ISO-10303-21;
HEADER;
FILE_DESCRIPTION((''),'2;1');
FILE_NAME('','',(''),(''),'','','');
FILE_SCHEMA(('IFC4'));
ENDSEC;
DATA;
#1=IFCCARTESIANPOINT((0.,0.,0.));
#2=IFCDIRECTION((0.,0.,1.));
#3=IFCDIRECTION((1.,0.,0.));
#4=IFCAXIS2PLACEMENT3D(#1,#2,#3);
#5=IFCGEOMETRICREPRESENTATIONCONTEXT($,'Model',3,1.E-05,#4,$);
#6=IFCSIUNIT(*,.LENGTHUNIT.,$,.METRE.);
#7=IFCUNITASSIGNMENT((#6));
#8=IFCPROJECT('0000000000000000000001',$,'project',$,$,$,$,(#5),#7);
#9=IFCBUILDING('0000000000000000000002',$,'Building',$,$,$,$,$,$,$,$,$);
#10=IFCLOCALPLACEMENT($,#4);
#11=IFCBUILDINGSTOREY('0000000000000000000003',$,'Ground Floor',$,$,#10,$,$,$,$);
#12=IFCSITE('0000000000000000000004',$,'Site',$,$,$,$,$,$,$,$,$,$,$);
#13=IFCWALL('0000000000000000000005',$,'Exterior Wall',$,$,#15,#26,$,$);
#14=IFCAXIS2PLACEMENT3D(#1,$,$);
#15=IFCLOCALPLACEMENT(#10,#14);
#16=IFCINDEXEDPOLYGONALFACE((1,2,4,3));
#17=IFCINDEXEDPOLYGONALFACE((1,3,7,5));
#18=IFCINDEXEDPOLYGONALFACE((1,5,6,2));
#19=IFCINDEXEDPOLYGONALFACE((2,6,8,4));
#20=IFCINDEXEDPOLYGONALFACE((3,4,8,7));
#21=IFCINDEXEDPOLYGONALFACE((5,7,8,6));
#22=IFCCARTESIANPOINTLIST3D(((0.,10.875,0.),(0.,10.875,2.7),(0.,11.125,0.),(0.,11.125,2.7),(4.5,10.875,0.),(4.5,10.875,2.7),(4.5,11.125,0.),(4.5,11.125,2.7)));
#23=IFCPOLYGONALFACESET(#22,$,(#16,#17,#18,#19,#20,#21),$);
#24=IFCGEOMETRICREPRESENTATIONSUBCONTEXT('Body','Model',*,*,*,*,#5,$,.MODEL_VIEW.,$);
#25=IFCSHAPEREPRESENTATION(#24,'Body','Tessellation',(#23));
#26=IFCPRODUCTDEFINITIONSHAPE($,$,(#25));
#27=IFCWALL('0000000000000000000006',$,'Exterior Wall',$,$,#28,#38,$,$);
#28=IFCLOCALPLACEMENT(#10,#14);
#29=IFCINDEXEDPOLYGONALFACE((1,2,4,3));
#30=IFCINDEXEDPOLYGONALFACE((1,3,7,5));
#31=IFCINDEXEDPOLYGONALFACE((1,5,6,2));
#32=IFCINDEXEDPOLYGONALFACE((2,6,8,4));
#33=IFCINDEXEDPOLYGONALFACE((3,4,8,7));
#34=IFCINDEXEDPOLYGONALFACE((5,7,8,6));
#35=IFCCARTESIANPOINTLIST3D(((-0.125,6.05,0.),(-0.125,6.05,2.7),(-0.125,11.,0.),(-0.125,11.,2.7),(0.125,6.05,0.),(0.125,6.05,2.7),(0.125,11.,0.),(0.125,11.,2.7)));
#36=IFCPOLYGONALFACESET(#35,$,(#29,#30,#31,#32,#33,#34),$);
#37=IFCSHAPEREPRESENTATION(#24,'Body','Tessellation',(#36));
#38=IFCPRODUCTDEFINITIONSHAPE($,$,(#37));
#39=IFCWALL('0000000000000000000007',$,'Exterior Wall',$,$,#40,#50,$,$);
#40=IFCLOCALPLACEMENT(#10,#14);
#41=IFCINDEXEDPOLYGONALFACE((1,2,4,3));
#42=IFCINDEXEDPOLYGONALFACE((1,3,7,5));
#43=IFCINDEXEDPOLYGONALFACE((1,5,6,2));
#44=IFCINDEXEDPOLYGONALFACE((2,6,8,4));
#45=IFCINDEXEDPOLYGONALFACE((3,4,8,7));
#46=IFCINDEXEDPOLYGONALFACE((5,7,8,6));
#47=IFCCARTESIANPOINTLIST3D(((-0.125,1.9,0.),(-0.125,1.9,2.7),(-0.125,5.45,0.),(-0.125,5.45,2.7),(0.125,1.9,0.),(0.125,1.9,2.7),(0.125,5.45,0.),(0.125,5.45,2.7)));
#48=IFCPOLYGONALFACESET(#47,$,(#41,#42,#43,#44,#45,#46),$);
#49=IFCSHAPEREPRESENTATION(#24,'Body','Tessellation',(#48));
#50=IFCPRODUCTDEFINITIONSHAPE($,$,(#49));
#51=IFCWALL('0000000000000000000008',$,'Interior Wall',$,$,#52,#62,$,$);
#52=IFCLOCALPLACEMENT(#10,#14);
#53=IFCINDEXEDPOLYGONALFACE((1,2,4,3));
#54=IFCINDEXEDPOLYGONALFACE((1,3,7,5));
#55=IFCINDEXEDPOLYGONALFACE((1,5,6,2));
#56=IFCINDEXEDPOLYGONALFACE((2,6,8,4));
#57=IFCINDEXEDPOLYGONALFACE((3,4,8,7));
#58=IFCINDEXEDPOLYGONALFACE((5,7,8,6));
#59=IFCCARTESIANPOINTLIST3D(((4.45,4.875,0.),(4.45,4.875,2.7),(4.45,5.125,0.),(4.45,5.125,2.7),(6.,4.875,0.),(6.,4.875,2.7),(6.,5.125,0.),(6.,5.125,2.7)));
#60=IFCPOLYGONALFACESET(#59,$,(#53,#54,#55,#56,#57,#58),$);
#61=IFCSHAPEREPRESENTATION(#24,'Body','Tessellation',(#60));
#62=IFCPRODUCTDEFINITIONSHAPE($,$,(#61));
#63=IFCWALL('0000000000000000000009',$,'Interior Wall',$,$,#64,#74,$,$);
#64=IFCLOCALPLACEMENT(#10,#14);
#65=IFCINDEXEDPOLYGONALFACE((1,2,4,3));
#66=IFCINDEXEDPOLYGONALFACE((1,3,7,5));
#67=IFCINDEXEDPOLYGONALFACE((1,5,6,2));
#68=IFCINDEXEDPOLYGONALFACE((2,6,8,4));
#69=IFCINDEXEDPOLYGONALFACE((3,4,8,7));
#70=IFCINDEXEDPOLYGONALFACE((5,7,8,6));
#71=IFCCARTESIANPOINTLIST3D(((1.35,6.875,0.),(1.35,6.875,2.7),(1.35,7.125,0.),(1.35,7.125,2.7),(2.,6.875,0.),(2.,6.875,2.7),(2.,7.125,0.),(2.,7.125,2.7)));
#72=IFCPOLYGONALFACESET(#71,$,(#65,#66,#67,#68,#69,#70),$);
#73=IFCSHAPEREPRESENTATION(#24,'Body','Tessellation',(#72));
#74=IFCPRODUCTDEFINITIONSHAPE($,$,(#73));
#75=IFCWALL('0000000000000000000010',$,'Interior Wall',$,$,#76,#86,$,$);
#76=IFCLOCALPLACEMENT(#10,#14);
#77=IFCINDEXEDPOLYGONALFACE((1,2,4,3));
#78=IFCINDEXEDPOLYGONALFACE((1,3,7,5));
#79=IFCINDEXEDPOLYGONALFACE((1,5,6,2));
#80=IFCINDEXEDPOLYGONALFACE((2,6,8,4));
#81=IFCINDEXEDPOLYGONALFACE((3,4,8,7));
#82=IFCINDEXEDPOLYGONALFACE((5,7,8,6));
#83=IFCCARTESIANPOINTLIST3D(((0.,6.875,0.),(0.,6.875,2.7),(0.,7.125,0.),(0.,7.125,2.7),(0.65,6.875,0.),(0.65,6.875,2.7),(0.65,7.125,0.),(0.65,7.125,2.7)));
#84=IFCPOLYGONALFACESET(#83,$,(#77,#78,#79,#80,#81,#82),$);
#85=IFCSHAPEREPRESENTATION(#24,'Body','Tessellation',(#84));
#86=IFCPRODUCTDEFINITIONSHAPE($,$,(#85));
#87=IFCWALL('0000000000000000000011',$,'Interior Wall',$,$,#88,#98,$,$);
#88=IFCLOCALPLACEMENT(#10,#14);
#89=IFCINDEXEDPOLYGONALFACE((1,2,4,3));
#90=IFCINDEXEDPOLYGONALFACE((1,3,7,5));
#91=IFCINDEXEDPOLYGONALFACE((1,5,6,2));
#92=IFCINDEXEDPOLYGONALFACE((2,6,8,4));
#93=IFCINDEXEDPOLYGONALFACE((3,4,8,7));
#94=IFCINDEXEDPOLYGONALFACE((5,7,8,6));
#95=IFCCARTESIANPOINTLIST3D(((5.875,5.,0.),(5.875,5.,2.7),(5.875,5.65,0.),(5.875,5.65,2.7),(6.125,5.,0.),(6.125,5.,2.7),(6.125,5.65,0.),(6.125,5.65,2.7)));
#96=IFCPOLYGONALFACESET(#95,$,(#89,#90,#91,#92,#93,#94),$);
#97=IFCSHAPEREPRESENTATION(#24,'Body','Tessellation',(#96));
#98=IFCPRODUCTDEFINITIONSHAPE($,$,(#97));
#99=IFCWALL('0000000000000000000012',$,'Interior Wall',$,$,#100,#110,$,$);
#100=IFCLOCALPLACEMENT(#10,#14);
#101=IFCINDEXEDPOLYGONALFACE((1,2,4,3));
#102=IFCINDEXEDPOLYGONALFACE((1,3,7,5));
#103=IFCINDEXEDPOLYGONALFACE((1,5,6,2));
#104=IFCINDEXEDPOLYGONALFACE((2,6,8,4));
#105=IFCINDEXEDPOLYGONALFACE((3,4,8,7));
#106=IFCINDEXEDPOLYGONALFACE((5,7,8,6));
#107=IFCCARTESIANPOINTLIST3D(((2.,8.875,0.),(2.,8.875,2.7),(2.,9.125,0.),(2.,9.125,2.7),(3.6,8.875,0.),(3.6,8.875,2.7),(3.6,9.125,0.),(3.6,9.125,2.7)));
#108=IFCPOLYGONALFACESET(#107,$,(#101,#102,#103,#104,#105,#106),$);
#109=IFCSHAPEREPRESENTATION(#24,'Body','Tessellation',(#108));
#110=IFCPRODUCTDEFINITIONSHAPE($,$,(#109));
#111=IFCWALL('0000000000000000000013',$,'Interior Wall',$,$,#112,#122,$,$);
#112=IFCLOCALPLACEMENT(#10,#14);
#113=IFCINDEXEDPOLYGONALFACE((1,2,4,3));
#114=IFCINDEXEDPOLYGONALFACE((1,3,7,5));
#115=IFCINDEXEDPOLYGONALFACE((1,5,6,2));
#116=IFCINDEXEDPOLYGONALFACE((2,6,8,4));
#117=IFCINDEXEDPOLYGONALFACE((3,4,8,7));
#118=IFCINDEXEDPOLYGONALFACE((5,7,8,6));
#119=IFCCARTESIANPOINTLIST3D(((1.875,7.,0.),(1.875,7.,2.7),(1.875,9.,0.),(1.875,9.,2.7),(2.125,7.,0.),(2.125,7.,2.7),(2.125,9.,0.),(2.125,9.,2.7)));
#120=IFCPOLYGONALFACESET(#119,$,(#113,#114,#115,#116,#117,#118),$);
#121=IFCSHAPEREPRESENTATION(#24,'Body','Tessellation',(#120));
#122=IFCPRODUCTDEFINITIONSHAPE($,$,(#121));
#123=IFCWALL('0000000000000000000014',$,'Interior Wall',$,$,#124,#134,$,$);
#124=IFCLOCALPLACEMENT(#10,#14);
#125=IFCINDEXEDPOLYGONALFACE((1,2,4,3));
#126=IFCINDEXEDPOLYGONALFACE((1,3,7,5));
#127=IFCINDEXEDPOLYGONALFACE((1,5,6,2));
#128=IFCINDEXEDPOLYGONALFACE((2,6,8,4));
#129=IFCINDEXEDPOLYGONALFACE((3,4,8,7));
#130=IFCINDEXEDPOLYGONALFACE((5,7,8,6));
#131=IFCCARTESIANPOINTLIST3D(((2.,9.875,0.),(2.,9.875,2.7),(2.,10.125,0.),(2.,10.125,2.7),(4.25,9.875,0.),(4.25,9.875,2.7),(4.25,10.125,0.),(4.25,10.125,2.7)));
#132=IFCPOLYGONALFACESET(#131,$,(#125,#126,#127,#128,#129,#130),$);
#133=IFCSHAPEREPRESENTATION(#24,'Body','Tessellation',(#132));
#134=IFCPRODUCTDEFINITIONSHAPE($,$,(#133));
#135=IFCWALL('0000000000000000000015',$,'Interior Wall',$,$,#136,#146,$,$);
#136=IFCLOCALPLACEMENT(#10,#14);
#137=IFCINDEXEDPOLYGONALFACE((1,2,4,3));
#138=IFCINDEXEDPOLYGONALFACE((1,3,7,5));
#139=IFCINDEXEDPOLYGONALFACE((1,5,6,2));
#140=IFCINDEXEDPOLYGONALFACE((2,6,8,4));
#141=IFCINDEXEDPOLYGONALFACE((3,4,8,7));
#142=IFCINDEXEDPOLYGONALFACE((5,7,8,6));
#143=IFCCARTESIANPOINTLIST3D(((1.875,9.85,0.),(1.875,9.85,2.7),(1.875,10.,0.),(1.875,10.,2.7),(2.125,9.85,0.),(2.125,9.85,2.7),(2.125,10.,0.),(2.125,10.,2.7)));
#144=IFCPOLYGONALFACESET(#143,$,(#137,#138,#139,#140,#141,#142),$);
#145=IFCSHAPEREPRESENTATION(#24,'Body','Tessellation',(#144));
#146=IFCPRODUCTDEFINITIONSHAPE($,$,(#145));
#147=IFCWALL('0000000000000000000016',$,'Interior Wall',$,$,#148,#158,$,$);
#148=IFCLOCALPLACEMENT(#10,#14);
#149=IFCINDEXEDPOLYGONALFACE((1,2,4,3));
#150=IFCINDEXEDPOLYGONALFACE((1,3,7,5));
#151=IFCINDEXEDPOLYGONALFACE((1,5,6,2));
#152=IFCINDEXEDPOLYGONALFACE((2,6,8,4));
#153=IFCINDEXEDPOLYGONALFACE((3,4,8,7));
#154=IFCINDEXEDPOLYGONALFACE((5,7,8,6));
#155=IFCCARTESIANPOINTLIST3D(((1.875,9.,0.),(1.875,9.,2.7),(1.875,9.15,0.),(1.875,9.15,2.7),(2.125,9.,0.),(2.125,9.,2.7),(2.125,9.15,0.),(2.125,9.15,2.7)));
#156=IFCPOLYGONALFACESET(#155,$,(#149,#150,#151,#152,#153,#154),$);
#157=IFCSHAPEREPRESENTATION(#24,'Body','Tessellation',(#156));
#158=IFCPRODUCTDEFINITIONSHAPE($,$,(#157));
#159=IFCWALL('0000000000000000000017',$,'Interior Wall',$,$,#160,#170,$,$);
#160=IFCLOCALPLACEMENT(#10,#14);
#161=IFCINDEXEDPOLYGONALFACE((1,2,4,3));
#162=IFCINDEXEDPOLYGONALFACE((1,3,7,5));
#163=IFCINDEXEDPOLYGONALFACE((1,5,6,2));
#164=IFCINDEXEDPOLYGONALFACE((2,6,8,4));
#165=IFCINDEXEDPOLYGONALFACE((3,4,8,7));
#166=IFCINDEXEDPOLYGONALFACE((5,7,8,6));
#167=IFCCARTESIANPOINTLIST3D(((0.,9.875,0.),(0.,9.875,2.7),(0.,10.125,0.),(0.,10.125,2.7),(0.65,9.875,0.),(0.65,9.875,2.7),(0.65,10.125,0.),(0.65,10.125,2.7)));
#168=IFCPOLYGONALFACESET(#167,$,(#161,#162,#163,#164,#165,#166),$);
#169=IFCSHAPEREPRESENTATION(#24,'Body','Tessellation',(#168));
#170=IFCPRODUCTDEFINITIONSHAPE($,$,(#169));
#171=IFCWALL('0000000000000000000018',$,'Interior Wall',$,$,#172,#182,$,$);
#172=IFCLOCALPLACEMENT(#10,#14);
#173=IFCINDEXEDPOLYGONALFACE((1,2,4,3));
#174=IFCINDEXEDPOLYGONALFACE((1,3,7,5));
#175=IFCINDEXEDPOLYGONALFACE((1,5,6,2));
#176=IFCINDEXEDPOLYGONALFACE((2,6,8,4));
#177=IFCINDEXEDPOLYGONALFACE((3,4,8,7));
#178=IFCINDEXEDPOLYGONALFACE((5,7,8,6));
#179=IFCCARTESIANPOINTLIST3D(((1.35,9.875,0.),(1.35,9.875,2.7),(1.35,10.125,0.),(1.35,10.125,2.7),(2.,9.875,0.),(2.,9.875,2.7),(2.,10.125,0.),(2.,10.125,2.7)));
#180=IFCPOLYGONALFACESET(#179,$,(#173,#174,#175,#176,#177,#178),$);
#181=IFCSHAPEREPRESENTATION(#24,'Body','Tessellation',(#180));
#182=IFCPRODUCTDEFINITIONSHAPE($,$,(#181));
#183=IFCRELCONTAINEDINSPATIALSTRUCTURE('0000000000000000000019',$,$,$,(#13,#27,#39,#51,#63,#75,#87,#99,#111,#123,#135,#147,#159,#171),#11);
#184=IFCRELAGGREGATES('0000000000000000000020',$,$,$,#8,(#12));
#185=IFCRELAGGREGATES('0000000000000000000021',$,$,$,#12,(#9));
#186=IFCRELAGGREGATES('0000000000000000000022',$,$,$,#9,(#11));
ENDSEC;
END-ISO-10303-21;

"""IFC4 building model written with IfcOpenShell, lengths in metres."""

from ifc_helpers import new_model, si_unit, frame, origin_with_axes, place, context, subcontext, project, spatial, indexed_curve, outline, extrude, element, save


model = new_model("IFC4")

# Units and contexts
model_context = context("Model", 3, precision=1e-05, world=origin_with_axes())
body_context = subcontext(model_context, "Body", "Model", "MODEL_VIEW")
ifc_project = project(units=[si_unit("LENGTHUNIT", "METRE")], contexts=[model_context])

# Site, building, storey
site = spatial("IfcSite", under=ifc_project, Name="Site")
building = spatial("IfcBuilding", under=site, Name="Building")
storey_placement = place(None, origin_with_axes())
storey = spatial("IfcBuildingStorey", under=building, at=storey_placement, Name="Ground Floor")

# Walls
wall_1_placement = place(storey_placement, frame((4.5, 11.0, 0.0), z_axis=(0.0, 0.0, 1.0), x_axis=(-1.0, 0.0, 0.0)))
element("IfcWall", 1, at=wall_1_placement, inside=storey, Name="Exterior Wall", context=body_context, shape_type="SweptSolid", body=[
    extrude(outline(indexed_curve([(0.0, 0.0), (0.0, 0.25), (4.5, 0.25), (4.5, 0.0), (0.0, 0.0)], self_intersect=False)), frame((0.0, -0.125, 0.0), z_axis=(0.0, 0.0, 1.0), x_axis=(1.0, 0.0, 0.0)), (0.0, 0.0, 1.0), 2.7),
])
wall_2_placement = place(storey_placement, frame((0.0, 11.0, 0.0), z_axis=(0.0, 0.0, 1.0), x_axis=(0.0, -1.0, 0.0)))
element("IfcWall", 2, at=wall_2_placement, inside=storey, Name="Exterior Wall", context=body_context, shape_type="SweptSolid", body=[
    extrude(outline(indexed_curve([(0.0, 0.0), (0.0, 0.25), (4.95, 0.25), (4.95, 0.0), (0.0, 0.0)], self_intersect=False)), frame((0.0, -0.125, 0.0), z_axis=(0.0, 0.0, 1.0), x_axis=(1.0, 0.0, 0.0)), (0.0, 0.0, 1.0), 2.7),
])
wall_3_placement = place(storey_placement, frame((0.0, 5.45, 0.0), z_axis=(0.0, 0.0, 1.0), x_axis=(0.0, -1.0, 0.0)))
element("IfcWall", 3, at=wall_3_placement, inside=storey, Name="Exterior Wall", context=body_context, shape_type="SweptSolid", body=[
    extrude(outline(indexed_curve([(0.0, 0.0), (0.0, 0.25), (3.55, 0.25), (3.55, 0.0), (0.0, 0.0)], self_intersect=False)), frame((0.0, -0.125, 0.0), z_axis=(0.0, 0.0, 1.0), x_axis=(1.0, 0.0, 0.0)), (0.0, 0.0, 1.0), 2.7),
])
wall_4_placement = place(storey_placement, frame((6.0, 5.0, 0.0), z_axis=(0.0, 0.0, 1.0), x_axis=(-1.0, 0.0, 0.0)))
element("IfcWall", 4, at=wall_4_placement, inside=storey, Name="Interior Wall", context=body_context, shape_type="SweptSolid", body=[
    extrude(outline(indexed_curve([(0.0, 0.0), (0.0, 0.25), (1.55, 0.25), (1.55, 0.0), (0.0, 0.0)], self_intersect=False)), frame((0.0, -0.125, 0.0), z_axis=(0.0, 0.0, 1.0), x_axis=(1.0, 0.0, 0.0)), (0.0, 0.0, 1.0), 2.7),
])
for number, where, z_axis, x_axis, name in (
    (5, (2.0, 7.0, 0.0), (0.0, 0.0, 1.0), (-1.0, 0.0, 0.0), "Interior Wall"),
    (6, (0.65, 7.0, 0.0), (0.0, 0.0, 1.0), (-1.0, 0.0, 0.0), "Interior Wall"),
):
    element("IfcWall", number, at=place(storey_placement, frame(where, z_axis=z_axis, x_axis=x_axis)), inside=storey, Name=name, context=body_context, shape_type="SweptSolid", body=[
        extrude(outline(indexed_curve([(0.0, 0.0), (0.0, 0.25), (0.65, 0.25), (0.65, 0.0), (0.0, 0.0)], self_intersect=False)), frame((0.0, -0.125, 0.0), z_axis=(0.0, 0.0, 1.0), x_axis=(1.0, 0.0, 0.0)), (0.0, 0.0, 1.0), 2.7),
    ])
wall_5_placement = place(storey_placement, frame((6.0, 5.0, 0.0), z_axis=(0.0, 0.0, 1.0), x_axis=(0.0, 1.0, 0.0)))
element("IfcWall", 7, at=wall_5_placement, inside=storey, Name="Interior Wall", context=body_context, shape_type="SweptSolid", body=[
    extrude(outline(indexed_curve([(0.0, 0.0), (0.0, 0.25), (0.65, 0.25), (0.65, 0.0), (0.0, 0.0)], self_intersect=False)), frame((0.0, -0.125, 0.0), z_axis=(0.0, 0.0, 1.0), x_axis=(1.0, 0.0, 0.0)), (0.0, 0.0, 1.0), 2.7),
])
wall_6_placement = place(storey_placement, frame((3.6, 9.0, 0.0), z_axis=(0.0, 0.0, 1.0), x_axis=(-1.0, 0.0, 0.0)))
element("IfcWall", 8, at=wall_6_placement, inside=storey, Name="Interior Wall", context=body_context, shape_type="SweptSolid", body=[
    extrude(outline(indexed_curve([(0.0, 0.0), (0.0, 0.25), (1.6, 0.25), (1.6, 0.0), (0.0, 0.0)], self_intersect=False)), frame((0.0, -0.125, 0.0), z_axis=(0.0, 0.0, 1.0), x_axis=(1.0, 0.0, 0.0)), (0.0, 0.0, 1.0), 2.7),
])
wall_7_placement = place(storey_placement, frame((2.0, 9.0, 0.0), z_axis=(0.0, 0.0, 1.0), x_axis=(0.0, -1.0, 0.0)))
element("IfcWall", 9, at=wall_7_placement, inside=storey, Name="Interior Wall", context=body_context, shape_type="SweptSolid", body=[
    extrude(outline(indexed_curve([(0.0, 0.0), (0.0, 0.25), (2.0, 0.25), (2.0, 0.0), (0.0, 0.0)], self_intersect=False)), frame((0.0, -0.125, 0.0), z_axis=(0.0, 0.0, 1.0), x_axis=(1.0, 0.0, 0.0)), (0.0, 0.0, 1.0), 2.7),
])
wall_8_placement = place(storey_placement, frame((4.25, 10.0, 0.0), z_axis=(0.0, 0.0, 1.0), x_axis=(-1.0, 0.0, 0.0)))
element("IfcWall", 10, at=wall_8_placement, inside=storey, Name="Interior Wall", context=body_context, shape_type="SweptSolid", body=[
    extrude(outline(indexed_curve([(0.0, 0.0), (0.0, 0.25), (2.25, 0.25), (2.25, 0.0), (0.0, 0.0)], self_intersect=False)), frame((0.0, -0.125, 0.0), z_axis=(0.0, 0.0, 1.0), x_axis=(1.0, 0.0, 0.0)), (0.0, 0.0, 1.0), 2.7),
])
for number, where, z_axis, x_axis, name in (
    (11, (2.0, 10.0, 0.0), (0.0, 0.0, 1.0), (0.0, -1.0, 0.0), "Interior Wall"),
    (12, (2.0, 9.15, 0.0), (0.0, 0.0, 1.0), (0.0, -1.0, 0.0), "Interior Wall"),
):
    element("IfcWall", number, at=place(storey_placement, frame(where, z_axis=z_axis, x_axis=x_axis)), inside=storey, Name=name, context=body_context, shape_type="SweptSolid", body=[
        extrude(outline(indexed_curve([(0.0, 0.0), (0.0, 0.25), (0.15, 0.25), (0.15, 0.0), (0.0, 0.0)], self_intersect=False)), frame((0.0, -0.125, 0.0), z_axis=(0.0, 0.0, 1.0), x_axis=(1.0, 0.0, 0.0)), (0.0, 0.0, 1.0), 2.7),
    ])
wall_9_placement = place(storey_placement, frame((0.0, 10.0, 0.0), z_axis=(0.0, 0.0, 1.0), x_axis=(1.0, 0.0, 0.0)))
element("IfcWall", 13, at=wall_9_placement, inside=storey, Name="Interior Wall", context=body_context, shape_type="SweptSolid", body=[
    extrude(outline(indexed_curve([(0.0, 0.0), (0.0, 0.25), (0.65, 0.25), (0.65, 0.0), (0.0, 0.0)], self_intersect=False)), frame((0.0, -0.125, 0.0), z_axis=(0.0, 0.0, 1.0), x_axis=(1.0, 0.0, 0.0)), (0.0, 0.0, 1.0), 2.7),
])
wall_10_placement = place(storey_placement, frame((1.35, 10.0, 0.0), z_axis=(0.0, 0.0, 1.0), x_axis=(1.0, 0.0, 0.0)))
element("IfcWall", 14, at=wall_10_placement, inside=storey, Name="Interior Wall", context=body_context, shape_type="SweptSolid", body=[
    extrude(outline(indexed_curve([(0.0, 0.0), (0.0, 0.25), (0.65, 0.25), (0.65, 0.0), (0.0, 0.0)], self_intersect=False)), frame((0.0, -0.125, 0.0), z_axis=(0.0, 0.0, 1.0), x_axis=(1.0, 0.0, 0.0)), (0.0, 0.0, 1.0), 2.7),
])

save(model, "model.ifc")
